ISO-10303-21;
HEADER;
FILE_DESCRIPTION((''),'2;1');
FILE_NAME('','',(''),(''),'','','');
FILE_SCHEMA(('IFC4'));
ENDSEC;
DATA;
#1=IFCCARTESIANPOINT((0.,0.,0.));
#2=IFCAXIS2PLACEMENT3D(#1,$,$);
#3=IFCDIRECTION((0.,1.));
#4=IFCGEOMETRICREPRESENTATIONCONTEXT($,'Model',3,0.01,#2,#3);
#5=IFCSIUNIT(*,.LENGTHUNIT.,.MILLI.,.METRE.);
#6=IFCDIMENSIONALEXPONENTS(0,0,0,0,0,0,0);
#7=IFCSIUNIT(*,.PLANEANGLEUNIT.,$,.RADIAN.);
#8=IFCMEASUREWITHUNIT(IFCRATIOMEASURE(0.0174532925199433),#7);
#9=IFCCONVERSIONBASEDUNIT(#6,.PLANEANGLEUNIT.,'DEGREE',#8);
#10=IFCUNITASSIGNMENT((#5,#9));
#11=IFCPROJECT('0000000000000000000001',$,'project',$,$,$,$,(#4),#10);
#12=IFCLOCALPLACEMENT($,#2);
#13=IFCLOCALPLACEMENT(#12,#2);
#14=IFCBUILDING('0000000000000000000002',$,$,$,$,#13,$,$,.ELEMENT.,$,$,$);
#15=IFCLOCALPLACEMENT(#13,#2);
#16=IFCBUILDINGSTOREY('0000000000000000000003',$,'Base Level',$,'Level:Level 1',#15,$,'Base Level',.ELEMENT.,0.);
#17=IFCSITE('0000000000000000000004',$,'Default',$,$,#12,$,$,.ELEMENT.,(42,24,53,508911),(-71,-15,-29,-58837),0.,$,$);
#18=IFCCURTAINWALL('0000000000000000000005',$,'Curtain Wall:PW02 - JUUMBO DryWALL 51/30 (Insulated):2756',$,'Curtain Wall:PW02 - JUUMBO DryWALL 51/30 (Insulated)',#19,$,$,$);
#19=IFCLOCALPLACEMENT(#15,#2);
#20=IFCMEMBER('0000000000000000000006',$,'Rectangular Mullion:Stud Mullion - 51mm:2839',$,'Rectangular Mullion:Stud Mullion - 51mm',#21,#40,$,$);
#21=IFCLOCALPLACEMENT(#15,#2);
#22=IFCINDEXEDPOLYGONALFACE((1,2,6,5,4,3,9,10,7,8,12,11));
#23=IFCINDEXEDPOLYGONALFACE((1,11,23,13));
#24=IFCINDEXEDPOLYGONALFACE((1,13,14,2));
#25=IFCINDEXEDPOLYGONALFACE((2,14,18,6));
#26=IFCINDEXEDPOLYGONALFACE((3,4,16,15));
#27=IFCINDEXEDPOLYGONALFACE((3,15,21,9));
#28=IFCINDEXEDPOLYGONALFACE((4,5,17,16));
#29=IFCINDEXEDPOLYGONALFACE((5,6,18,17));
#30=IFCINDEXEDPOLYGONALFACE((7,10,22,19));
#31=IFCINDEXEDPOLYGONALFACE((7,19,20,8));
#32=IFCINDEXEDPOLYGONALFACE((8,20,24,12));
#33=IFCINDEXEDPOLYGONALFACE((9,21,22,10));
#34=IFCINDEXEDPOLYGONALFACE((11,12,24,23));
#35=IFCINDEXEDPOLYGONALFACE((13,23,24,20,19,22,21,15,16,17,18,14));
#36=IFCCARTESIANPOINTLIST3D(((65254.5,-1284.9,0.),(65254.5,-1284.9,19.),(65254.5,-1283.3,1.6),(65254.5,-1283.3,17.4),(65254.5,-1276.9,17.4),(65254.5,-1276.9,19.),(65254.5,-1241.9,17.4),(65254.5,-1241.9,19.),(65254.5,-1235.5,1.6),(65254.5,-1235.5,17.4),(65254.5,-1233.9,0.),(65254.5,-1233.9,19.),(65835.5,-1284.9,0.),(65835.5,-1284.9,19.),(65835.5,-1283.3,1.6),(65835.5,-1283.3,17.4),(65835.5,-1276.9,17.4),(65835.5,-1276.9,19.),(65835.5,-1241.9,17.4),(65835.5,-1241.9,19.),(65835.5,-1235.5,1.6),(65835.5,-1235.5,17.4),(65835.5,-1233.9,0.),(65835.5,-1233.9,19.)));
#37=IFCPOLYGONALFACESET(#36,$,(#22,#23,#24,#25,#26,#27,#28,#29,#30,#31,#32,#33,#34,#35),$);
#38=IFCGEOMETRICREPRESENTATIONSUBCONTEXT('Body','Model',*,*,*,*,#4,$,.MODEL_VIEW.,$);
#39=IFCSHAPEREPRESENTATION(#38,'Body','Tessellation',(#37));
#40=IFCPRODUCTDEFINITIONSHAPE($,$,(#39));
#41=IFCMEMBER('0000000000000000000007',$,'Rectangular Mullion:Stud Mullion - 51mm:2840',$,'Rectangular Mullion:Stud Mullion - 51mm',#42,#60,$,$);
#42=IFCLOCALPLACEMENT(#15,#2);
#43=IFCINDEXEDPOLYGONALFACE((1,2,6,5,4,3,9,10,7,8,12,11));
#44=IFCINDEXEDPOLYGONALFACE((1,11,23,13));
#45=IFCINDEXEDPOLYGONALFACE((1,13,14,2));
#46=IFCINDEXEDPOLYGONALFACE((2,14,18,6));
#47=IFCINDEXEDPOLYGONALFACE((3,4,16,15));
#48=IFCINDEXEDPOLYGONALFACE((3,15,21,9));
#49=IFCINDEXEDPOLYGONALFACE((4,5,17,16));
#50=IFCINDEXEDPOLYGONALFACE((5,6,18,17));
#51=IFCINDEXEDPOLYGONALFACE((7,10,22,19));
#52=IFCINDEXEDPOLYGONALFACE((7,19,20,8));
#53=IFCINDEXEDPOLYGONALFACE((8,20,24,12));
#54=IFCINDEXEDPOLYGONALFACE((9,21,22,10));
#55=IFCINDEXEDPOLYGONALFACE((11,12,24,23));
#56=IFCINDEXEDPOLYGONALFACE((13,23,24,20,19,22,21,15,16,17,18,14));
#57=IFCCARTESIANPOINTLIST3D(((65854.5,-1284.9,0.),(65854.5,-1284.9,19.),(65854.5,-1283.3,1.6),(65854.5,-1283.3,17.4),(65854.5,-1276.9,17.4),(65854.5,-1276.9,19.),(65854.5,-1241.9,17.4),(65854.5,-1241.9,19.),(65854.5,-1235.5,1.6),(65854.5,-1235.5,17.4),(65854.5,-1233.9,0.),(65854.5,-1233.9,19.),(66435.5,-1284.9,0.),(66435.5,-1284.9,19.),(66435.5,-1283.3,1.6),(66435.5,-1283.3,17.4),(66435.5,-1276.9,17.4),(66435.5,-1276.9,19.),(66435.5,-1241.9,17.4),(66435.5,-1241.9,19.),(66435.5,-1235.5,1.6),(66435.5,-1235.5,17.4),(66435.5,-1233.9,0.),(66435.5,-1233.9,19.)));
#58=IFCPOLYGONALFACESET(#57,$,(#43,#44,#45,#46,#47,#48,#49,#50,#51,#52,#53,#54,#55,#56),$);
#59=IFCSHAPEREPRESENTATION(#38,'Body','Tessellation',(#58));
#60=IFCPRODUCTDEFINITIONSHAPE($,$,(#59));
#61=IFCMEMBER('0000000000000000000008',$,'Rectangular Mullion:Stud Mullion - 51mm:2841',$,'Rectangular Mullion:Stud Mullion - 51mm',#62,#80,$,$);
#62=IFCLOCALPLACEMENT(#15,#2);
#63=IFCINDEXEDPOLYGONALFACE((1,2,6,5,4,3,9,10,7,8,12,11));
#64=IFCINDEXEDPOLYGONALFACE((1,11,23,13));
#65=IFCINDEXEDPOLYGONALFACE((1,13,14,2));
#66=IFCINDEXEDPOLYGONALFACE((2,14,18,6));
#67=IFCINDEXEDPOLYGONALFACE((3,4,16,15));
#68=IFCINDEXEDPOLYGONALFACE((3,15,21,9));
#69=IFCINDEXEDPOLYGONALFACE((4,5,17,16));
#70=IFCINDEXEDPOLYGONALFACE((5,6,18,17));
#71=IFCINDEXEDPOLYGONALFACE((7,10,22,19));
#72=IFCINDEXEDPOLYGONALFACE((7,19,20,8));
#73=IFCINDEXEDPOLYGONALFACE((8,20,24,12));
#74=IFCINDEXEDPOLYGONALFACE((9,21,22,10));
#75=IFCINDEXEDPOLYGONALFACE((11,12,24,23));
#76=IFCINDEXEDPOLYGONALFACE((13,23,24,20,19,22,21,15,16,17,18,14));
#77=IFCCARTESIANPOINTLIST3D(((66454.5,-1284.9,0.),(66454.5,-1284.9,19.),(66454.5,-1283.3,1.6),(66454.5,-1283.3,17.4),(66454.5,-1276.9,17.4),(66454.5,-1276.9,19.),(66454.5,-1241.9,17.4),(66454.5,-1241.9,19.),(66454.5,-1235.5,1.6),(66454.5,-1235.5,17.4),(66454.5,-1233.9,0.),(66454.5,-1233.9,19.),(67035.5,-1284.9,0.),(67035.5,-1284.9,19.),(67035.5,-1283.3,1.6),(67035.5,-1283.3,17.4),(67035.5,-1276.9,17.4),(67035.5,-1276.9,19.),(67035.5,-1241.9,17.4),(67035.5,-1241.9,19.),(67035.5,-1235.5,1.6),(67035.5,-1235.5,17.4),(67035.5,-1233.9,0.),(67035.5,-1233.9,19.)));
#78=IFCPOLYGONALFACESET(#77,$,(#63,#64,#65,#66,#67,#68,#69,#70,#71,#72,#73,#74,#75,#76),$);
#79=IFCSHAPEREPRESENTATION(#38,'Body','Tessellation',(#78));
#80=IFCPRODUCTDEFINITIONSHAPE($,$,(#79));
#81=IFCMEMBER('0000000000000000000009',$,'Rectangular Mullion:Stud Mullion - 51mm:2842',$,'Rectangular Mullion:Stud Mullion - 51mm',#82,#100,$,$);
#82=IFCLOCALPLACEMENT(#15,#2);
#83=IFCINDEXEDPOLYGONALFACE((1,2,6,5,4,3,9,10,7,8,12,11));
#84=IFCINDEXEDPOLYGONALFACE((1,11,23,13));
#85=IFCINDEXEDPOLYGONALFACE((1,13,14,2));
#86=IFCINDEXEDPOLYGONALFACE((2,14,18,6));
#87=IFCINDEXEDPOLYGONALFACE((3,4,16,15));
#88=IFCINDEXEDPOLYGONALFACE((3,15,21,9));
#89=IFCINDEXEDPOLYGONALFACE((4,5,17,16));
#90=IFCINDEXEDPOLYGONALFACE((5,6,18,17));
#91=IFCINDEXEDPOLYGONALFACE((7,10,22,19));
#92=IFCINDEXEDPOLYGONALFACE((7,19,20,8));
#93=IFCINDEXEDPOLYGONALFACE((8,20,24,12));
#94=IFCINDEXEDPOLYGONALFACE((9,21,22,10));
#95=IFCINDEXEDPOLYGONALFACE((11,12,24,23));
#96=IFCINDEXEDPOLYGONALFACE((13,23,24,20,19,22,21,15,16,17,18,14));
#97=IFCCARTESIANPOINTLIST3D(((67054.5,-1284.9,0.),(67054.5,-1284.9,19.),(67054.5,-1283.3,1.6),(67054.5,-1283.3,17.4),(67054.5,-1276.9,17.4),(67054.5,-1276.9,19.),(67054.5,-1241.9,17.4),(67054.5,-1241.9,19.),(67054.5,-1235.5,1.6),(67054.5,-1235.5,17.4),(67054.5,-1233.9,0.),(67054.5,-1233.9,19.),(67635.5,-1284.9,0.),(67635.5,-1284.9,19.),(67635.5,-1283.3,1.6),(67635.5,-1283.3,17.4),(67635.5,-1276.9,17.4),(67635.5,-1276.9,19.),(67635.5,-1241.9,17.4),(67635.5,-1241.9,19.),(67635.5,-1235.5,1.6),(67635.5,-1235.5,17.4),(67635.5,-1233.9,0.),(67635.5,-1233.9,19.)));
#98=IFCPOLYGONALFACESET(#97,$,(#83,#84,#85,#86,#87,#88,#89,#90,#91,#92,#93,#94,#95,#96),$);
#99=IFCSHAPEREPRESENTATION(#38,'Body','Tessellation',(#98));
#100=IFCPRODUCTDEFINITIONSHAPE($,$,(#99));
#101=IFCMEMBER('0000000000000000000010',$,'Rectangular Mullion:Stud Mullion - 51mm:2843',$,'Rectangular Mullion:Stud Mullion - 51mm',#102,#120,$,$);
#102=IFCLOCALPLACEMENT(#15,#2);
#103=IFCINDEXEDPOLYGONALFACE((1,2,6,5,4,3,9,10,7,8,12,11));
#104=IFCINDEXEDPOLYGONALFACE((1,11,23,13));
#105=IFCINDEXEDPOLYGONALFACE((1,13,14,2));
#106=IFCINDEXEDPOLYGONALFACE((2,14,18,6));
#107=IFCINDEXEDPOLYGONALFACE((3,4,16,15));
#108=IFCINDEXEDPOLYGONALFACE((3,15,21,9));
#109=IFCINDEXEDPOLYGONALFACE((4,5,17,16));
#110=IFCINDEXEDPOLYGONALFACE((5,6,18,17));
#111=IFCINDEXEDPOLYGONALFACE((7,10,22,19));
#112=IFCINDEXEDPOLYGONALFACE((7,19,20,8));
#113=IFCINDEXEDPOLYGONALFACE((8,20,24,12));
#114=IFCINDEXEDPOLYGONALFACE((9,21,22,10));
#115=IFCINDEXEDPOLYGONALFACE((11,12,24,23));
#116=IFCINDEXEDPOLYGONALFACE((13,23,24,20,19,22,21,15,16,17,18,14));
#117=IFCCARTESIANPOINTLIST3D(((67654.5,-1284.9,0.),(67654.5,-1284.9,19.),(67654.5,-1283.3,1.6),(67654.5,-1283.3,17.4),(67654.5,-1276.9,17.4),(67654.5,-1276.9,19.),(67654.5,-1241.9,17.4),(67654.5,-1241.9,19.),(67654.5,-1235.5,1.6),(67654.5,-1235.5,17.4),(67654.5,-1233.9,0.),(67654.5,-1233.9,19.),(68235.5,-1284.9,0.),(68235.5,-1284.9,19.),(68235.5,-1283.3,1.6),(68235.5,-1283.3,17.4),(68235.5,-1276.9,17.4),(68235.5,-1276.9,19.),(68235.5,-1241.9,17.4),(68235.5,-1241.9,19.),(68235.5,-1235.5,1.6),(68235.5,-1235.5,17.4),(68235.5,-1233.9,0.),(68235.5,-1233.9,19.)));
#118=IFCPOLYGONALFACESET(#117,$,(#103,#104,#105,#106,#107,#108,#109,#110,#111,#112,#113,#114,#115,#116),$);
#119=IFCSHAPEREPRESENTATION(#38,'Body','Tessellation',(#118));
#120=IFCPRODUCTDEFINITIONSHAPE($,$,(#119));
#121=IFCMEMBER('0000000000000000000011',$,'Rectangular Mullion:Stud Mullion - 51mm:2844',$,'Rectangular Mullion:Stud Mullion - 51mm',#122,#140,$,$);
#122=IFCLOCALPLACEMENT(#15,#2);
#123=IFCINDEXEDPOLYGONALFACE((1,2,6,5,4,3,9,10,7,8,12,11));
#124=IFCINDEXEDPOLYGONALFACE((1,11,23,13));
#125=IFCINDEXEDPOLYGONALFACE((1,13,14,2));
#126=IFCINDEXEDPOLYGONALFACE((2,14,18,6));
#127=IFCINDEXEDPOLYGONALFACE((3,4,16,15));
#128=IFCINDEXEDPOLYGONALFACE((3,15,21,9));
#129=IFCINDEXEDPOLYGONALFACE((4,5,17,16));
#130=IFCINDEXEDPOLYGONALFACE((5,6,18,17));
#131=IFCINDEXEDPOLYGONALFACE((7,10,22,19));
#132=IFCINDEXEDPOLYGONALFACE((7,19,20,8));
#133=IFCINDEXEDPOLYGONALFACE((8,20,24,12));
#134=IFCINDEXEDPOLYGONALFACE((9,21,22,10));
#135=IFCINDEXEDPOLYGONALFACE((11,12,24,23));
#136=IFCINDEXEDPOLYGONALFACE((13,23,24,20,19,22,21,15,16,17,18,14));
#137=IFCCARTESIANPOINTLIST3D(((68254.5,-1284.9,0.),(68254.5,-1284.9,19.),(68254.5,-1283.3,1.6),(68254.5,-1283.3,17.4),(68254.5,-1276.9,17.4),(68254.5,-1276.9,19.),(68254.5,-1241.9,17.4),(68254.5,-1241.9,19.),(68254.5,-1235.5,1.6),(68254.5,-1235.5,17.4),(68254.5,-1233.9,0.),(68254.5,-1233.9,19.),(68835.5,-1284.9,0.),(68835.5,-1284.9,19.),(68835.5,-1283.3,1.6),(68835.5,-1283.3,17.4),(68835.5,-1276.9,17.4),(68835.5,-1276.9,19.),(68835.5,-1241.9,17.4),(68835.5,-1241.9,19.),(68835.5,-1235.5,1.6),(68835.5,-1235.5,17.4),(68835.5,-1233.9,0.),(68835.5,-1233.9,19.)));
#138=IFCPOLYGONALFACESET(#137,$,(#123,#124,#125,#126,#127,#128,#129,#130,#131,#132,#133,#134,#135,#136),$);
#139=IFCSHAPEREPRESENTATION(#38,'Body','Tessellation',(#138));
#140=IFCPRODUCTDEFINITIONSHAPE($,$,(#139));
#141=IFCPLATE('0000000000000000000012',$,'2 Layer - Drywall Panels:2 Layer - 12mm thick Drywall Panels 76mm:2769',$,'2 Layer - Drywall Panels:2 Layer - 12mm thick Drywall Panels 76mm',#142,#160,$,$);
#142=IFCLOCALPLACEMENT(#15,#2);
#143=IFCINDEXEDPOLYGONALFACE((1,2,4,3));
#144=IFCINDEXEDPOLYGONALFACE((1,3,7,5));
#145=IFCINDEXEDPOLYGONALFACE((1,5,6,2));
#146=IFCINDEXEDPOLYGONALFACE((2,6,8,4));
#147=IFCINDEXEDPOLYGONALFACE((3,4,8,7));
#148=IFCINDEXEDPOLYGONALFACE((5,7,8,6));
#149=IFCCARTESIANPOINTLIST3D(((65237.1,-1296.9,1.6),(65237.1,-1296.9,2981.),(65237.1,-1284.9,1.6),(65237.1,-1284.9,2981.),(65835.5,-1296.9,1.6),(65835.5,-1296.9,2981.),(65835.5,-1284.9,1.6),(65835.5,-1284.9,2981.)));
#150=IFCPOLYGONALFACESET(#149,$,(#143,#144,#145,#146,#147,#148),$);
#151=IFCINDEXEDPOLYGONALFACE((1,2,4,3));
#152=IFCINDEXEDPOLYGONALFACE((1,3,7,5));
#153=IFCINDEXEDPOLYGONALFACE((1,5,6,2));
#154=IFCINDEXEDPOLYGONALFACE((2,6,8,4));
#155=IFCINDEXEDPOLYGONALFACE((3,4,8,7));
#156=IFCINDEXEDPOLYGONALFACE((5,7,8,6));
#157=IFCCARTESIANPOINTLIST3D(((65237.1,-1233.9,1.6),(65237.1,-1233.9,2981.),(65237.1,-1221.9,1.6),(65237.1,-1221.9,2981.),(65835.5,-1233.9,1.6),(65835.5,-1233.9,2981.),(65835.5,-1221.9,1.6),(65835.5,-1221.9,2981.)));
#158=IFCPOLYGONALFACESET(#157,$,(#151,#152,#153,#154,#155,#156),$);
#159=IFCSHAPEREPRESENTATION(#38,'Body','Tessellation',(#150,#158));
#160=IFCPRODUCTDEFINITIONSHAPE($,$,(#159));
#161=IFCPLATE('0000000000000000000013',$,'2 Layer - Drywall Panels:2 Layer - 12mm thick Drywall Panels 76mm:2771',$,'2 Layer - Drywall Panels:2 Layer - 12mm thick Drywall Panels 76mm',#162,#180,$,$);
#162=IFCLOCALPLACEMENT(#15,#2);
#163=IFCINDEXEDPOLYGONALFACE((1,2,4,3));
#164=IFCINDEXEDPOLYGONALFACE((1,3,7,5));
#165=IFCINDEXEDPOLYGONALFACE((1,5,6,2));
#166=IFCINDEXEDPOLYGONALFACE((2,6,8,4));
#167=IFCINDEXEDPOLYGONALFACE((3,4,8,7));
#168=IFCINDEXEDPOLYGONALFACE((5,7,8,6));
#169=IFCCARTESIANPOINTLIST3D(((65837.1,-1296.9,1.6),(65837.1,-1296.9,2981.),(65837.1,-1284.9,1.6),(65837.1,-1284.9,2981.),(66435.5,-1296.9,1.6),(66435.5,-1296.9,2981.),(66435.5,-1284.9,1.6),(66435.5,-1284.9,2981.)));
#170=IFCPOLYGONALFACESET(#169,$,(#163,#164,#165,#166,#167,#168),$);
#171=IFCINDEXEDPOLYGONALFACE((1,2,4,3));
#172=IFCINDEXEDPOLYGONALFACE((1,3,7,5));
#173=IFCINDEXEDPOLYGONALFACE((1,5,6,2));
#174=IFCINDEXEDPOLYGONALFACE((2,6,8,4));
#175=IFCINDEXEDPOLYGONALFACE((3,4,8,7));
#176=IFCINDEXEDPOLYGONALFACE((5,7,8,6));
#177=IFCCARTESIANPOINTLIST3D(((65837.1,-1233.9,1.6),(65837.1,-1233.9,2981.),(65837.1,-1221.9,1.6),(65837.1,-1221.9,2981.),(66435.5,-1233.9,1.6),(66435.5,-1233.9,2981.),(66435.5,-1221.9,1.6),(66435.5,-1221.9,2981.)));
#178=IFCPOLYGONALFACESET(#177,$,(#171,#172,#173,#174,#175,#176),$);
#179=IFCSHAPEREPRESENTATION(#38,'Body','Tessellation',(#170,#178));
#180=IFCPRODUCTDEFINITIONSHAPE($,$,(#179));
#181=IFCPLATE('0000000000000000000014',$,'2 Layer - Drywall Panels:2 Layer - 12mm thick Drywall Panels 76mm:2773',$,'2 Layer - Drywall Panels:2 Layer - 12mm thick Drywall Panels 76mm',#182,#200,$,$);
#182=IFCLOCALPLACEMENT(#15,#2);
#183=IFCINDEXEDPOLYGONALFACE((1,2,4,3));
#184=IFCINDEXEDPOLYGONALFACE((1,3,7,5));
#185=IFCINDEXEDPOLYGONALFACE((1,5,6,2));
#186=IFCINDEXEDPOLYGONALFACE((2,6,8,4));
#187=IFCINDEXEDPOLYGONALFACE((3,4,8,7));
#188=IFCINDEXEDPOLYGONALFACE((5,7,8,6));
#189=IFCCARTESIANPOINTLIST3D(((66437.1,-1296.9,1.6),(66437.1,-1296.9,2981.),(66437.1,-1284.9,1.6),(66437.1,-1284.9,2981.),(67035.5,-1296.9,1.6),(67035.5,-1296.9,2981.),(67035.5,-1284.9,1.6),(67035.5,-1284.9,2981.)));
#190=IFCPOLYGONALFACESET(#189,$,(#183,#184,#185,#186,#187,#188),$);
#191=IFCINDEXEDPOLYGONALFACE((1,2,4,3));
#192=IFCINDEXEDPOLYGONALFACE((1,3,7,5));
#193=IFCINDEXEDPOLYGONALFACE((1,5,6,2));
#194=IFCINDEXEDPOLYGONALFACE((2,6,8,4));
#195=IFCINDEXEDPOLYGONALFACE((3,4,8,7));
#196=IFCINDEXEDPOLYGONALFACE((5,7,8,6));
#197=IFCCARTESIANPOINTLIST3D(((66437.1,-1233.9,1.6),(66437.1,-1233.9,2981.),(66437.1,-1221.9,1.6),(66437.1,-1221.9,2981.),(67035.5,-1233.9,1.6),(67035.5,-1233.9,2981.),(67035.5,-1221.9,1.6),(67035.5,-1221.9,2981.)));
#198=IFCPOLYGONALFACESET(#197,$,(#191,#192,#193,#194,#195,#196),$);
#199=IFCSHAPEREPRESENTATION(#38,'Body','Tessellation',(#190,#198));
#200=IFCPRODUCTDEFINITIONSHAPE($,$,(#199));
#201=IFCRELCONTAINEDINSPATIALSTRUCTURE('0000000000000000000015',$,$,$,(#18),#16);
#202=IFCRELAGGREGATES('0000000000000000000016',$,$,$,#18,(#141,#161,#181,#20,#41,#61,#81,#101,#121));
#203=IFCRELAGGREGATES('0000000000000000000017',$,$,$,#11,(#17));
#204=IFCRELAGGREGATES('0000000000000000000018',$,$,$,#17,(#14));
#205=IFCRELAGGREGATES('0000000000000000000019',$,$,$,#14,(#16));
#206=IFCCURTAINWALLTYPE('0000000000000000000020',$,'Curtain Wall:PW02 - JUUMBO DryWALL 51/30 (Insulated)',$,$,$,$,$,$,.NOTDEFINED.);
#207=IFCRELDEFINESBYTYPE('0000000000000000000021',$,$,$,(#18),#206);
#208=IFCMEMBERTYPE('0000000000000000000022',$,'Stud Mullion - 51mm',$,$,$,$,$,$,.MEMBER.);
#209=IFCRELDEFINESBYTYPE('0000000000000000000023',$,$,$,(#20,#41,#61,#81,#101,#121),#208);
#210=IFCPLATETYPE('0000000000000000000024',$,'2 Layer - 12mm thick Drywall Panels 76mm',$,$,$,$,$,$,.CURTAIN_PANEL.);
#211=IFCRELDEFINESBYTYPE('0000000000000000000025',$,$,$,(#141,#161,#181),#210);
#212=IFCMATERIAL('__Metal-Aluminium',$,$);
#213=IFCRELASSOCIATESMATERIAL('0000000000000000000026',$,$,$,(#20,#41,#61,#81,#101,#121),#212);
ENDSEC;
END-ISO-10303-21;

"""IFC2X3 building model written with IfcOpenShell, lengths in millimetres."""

from ifc_helpers import new_model, entity, si_unit, converted_unit, direction, frame, frame_2d, origin, origin_2d_with_axis, place, context, subcontext, project, spatial, polyline, rectangle, outline, extrude, source, transform, mapped, material, type_object, type_shapes, element, aggregate, save


model = new_model("IFC2X3")

# Units and contexts
model_context = context("Model", 3, precision=0.01, world=origin(), true_north=direction((0.0, 1.0)))
body_context = subcontext(model_context, "Body", "Model", "MODEL_VIEW")
ifc_project = project(units=[si_unit("LENGTHUNIT", "METRE", prefix="MILLI"), converted_unit("PLANEANGLEUNIT", "DEGREE", entity("IfcRatioMeasure", 0.0174532925199433), si_unit("PLANEANGLEUNIT", "RADIAN"), dimensions=[0, 0, 0, 0, 0, 0, 0])], contexts=[model_context])

# Site, building, storey
site_placement = place(None, origin())
site = spatial("IfcSite", under=ifc_project, at=site_placement, Name="Default", CompositionType="ELEMENT", RefLatitude=(42, 24, 53, 508911), RefLongitude=(-71, -15, -29, -58837), RefElevation=0.0)
building_placement = place(site_placement, origin())
building = spatial("IfcBuilding", under=site, at=building_placement, CompositionType="ELEMENT")
storey_placement = place(building_placement, origin())
storey = spatial("IfcBuildingStorey", under=building, at=storey_placement, Name="Base Level", ObjectType="Level:Level 1", LongName="Base Level", CompositionType="ELEMENT", Elevation=0.0)

# Curtain wall, members, plates
curtain_wall_type = type_object("IfcCurtainWallType", Name="Curtain Wall:PW02 - JUUMBO DryWALL 51/30 (Insulated)", PredefinedType="NOTDEFINED")
curtain_wall_placement = place(building_placement, origin())
curtain_wall = element("IfcCurtainWall", 1, at=curtain_wall_placement, inside=storey, type_object=curtain_wall_type, Name="Curtain Wall:PW02 - JUUMBO DryWALL 51/30 (Insulated):2756", ObjectType="Curtain Wall:PW02 - JUUMBO DryWALL 51/30 (Insulated)")
ifc_material = material(Name="__Metal-Aluminium")
member_type_1 = type_object("IfcMemberType", Name="Stud Mullion - 51mm", PredefinedType="MEMBER")
shared_shape_1 = source(origin(), body_context, "Body", "SweptSolid", [
    extrude(outline(polyline([(17.5, -6.6), (25.5, -6.6), (25.5, 12.4), (-25.5, 12.4), (-25.5, -6.6), (-17.5, -6.6), (-17.5, -5.0), (-23.9, -5.0), (-23.9, 10.8), (23.9, 10.8), (23.9, -5.0), (17.5, -5.0), (17.5, -6.6)])), frame((-12.4, 0.0, -581.0), z_axis=(0.0, 0.0, 1.0), x_axis=(0.0, -1.0, 0.0)), (0.0, 0.0, 1.0), 581.0),
])
type_shapes(member_type_1, [shared_shape_1])
member_1_placement = place(building_placement, frame((65254.5, -1259.4, 0.0), z_axis=(-1.0, 0.0, 0.0), x_axis=(0.0, 0.0, -1.0)))
member_1 = element("IfcMember", 2, at=member_1_placement, type_object=member_type_1, material=ifc_material, Name="Rectangular Mullion:Stud Mullion - 51mm:2839", ObjectType="Rectangular Mullion:Stud Mullion - 51mm", context=body_context, shape_type="MappedRepresentation", body=[
    mapped(shared_shape_1, transform((0.0, 0.0, 0.0), scale=1.0)),
])
member_2_placement = place(building_placement, frame((65854.5, -1259.4, 0.0), z_axis=(-1.0, 0.0, 0.0), x_axis=(0.0, 0.0, -1.0)))
member_2 = element("IfcMember", 3, at=member_2_placement, type_object=member_type_1, material=ifc_material, Name="Rectangular Mullion:Stud Mullion - 51mm:2840", ObjectType="Rectangular Mullion:Stud Mullion - 51mm", context=body_context, shape_type="MappedRepresentation", body=[
    mapped(shared_shape_1, transform((0.0, 0.0, 0.0), scale=1.0)),
])
member_3_placement = place(building_placement, frame((66454.5, -1259.4, 0.0), z_axis=(-1.0, 0.0, 0.0), x_axis=(0.0, 0.0, -1.0)))
member_3 = element("IfcMember", 4, at=member_3_placement, type_object=member_type_1, material=ifc_material, Name="Rectangular Mullion:Stud Mullion - 51mm:2841", ObjectType="Rectangular Mullion:Stud Mullion - 51mm", context=body_context, shape_type="MappedRepresentation", body=[
    mapped(shared_shape_1, transform((0.0, 0.0, 0.0), scale=1.0)),
])
member_4_placement = place(building_placement, frame((67054.5, -1259.4, 0.0), z_axis=(-1.0, 0.0, 0.0), x_axis=(0.0, 0.0, -1.0)))
member_4 = element("IfcMember", 5, at=member_4_placement, type_object=member_type_1, material=ifc_material, Name="Rectangular Mullion:Stud Mullion - 51mm:2842", ObjectType="Rectangular Mullion:Stud Mullion - 51mm", context=body_context, shape_type="MappedRepresentation", body=[
    mapped(shared_shape_1, transform((0.0, 0.0, 0.0), scale=1.0)),
])
member_5_placement = place(building_placement, frame((67654.5, -1259.4, 0.0), z_axis=(-1.0, 0.0, 0.0), x_axis=(0.0, 0.0, -1.0)))
member_5 = element("IfcMember", 6, at=member_5_placement, type_object=member_type_1, material=ifc_material, Name="Rectangular Mullion:Stud Mullion - 51mm:2843", ObjectType="Rectangular Mullion:Stud Mullion - 51mm", context=body_context, shape_type="MappedRepresentation", body=[
    mapped(shared_shape_1, transform((0.0, 0.0, 0.0), scale=1.0)),
])
member_6_placement = place(building_placement, frame((68254.5, -1259.4, 0.0), z_axis=(-1.0, 0.0, 0.0), x_axis=(0.0, 0.0, -1.0)))
member_6 = element("IfcMember", 7, at=member_6_placement, type_object=member_type_1, material=ifc_material, Name="Rectangular Mullion:Stud Mullion - 51mm:2844", ObjectType="Rectangular Mullion:Stud Mullion - 51mm", context=body_context, shape_type="MappedRepresentation", body=[
    mapped(shared_shape_1, transform((0.0, 0.0, 0.0), scale=1.0)),
])
plate_type = type_object("IfcPlateType", Name="2 Layer - 12mm thick Drywall Panels 76mm", PredefinedType="CURTAIN_PANEL")
shared_shape_2 = source(origin(), body_context, "Body", "SweptSolid", [
    extrude(rectangle(XDim=598.4, YDim=12.0, at=origin_2d_with_axis()), frame((0.0, -31.5, 0.0), z_axis=(0.0, 0.0, 1.0), x_axis=(-1.0, 0.0, 0.0)), (0.0, 0.0, 1.0), 2979.4),
    extrude(rectangle(XDim=12.0, YDim=598.4, at=frame_2d((0.0, 0.0), x_axis=(1.0, 0.0))), frame((0.0, 31.5, 0.0), z_axis=(0.0, 0.0, 1.0), x_axis=(0.0, 1.0, 0.0)), (0.0, 0.0, 1.0), 2979.4),
])
type_shapes(plate_type, [shared_shape_2])
plate_1_placement = place(curtain_wall_placement, frame((65536.3, -1259.4, 1.6)))
plate_1 = element("IfcPlate", 8, at=plate_1_placement, type_object=plate_type, Name="2 Layer - Drywall Panels:2 Layer - 12mm thick Drywall Panels 76mm:2769", ObjectType="2 Layer - Drywall Panels:2 Layer - 12mm thick Drywall Panels 76mm", context=body_context, shape_type="MappedRepresentation", body=[
    mapped(shared_shape_2, transform((0.0, 0.0, 0.0), scale=1.0)),
])
plate_2_placement = place(curtain_wall_placement, frame((66136.3, -1259.4, 1.6)))
plate_2 = element("IfcPlate", 9, at=plate_2_placement, type_object=plate_type, Name="2 Layer - Drywall Panels:2 Layer - 12mm thick Drywall Panels 76mm:2771", ObjectType="2 Layer - Drywall Panels:2 Layer - 12mm thick Drywall Panels 76mm", context=body_context, shape_type="MappedRepresentation", body=[
    mapped(shared_shape_2, transform((0.0, 0.0, 0.0), scale=1.0)),
])
plate_3_placement = place(curtain_wall_placement, frame((66736.3, -1259.4, 1.6)))
plate_3 = element("IfcPlate", 10, at=plate_3_placement, type_object=plate_type, Name="2 Layer - Drywall Panels:2 Layer - 12mm thick Drywall Panels 76mm:2773", ObjectType="2 Layer - Drywall Panels:2 Layer - 12mm thick Drywall Panels 76mm", context=body_context, shape_type="MappedRepresentation", body=[
    mapped(shared_shape_2, transform((0.0, 0.0, 0.0), scale=1.0)),
])
aggregate(curtain_wall, [plate_1, plate_2, plate_3, member_1, member_2, member_3, member_4, member_5, member_6])

save(model, "model.ifc")
